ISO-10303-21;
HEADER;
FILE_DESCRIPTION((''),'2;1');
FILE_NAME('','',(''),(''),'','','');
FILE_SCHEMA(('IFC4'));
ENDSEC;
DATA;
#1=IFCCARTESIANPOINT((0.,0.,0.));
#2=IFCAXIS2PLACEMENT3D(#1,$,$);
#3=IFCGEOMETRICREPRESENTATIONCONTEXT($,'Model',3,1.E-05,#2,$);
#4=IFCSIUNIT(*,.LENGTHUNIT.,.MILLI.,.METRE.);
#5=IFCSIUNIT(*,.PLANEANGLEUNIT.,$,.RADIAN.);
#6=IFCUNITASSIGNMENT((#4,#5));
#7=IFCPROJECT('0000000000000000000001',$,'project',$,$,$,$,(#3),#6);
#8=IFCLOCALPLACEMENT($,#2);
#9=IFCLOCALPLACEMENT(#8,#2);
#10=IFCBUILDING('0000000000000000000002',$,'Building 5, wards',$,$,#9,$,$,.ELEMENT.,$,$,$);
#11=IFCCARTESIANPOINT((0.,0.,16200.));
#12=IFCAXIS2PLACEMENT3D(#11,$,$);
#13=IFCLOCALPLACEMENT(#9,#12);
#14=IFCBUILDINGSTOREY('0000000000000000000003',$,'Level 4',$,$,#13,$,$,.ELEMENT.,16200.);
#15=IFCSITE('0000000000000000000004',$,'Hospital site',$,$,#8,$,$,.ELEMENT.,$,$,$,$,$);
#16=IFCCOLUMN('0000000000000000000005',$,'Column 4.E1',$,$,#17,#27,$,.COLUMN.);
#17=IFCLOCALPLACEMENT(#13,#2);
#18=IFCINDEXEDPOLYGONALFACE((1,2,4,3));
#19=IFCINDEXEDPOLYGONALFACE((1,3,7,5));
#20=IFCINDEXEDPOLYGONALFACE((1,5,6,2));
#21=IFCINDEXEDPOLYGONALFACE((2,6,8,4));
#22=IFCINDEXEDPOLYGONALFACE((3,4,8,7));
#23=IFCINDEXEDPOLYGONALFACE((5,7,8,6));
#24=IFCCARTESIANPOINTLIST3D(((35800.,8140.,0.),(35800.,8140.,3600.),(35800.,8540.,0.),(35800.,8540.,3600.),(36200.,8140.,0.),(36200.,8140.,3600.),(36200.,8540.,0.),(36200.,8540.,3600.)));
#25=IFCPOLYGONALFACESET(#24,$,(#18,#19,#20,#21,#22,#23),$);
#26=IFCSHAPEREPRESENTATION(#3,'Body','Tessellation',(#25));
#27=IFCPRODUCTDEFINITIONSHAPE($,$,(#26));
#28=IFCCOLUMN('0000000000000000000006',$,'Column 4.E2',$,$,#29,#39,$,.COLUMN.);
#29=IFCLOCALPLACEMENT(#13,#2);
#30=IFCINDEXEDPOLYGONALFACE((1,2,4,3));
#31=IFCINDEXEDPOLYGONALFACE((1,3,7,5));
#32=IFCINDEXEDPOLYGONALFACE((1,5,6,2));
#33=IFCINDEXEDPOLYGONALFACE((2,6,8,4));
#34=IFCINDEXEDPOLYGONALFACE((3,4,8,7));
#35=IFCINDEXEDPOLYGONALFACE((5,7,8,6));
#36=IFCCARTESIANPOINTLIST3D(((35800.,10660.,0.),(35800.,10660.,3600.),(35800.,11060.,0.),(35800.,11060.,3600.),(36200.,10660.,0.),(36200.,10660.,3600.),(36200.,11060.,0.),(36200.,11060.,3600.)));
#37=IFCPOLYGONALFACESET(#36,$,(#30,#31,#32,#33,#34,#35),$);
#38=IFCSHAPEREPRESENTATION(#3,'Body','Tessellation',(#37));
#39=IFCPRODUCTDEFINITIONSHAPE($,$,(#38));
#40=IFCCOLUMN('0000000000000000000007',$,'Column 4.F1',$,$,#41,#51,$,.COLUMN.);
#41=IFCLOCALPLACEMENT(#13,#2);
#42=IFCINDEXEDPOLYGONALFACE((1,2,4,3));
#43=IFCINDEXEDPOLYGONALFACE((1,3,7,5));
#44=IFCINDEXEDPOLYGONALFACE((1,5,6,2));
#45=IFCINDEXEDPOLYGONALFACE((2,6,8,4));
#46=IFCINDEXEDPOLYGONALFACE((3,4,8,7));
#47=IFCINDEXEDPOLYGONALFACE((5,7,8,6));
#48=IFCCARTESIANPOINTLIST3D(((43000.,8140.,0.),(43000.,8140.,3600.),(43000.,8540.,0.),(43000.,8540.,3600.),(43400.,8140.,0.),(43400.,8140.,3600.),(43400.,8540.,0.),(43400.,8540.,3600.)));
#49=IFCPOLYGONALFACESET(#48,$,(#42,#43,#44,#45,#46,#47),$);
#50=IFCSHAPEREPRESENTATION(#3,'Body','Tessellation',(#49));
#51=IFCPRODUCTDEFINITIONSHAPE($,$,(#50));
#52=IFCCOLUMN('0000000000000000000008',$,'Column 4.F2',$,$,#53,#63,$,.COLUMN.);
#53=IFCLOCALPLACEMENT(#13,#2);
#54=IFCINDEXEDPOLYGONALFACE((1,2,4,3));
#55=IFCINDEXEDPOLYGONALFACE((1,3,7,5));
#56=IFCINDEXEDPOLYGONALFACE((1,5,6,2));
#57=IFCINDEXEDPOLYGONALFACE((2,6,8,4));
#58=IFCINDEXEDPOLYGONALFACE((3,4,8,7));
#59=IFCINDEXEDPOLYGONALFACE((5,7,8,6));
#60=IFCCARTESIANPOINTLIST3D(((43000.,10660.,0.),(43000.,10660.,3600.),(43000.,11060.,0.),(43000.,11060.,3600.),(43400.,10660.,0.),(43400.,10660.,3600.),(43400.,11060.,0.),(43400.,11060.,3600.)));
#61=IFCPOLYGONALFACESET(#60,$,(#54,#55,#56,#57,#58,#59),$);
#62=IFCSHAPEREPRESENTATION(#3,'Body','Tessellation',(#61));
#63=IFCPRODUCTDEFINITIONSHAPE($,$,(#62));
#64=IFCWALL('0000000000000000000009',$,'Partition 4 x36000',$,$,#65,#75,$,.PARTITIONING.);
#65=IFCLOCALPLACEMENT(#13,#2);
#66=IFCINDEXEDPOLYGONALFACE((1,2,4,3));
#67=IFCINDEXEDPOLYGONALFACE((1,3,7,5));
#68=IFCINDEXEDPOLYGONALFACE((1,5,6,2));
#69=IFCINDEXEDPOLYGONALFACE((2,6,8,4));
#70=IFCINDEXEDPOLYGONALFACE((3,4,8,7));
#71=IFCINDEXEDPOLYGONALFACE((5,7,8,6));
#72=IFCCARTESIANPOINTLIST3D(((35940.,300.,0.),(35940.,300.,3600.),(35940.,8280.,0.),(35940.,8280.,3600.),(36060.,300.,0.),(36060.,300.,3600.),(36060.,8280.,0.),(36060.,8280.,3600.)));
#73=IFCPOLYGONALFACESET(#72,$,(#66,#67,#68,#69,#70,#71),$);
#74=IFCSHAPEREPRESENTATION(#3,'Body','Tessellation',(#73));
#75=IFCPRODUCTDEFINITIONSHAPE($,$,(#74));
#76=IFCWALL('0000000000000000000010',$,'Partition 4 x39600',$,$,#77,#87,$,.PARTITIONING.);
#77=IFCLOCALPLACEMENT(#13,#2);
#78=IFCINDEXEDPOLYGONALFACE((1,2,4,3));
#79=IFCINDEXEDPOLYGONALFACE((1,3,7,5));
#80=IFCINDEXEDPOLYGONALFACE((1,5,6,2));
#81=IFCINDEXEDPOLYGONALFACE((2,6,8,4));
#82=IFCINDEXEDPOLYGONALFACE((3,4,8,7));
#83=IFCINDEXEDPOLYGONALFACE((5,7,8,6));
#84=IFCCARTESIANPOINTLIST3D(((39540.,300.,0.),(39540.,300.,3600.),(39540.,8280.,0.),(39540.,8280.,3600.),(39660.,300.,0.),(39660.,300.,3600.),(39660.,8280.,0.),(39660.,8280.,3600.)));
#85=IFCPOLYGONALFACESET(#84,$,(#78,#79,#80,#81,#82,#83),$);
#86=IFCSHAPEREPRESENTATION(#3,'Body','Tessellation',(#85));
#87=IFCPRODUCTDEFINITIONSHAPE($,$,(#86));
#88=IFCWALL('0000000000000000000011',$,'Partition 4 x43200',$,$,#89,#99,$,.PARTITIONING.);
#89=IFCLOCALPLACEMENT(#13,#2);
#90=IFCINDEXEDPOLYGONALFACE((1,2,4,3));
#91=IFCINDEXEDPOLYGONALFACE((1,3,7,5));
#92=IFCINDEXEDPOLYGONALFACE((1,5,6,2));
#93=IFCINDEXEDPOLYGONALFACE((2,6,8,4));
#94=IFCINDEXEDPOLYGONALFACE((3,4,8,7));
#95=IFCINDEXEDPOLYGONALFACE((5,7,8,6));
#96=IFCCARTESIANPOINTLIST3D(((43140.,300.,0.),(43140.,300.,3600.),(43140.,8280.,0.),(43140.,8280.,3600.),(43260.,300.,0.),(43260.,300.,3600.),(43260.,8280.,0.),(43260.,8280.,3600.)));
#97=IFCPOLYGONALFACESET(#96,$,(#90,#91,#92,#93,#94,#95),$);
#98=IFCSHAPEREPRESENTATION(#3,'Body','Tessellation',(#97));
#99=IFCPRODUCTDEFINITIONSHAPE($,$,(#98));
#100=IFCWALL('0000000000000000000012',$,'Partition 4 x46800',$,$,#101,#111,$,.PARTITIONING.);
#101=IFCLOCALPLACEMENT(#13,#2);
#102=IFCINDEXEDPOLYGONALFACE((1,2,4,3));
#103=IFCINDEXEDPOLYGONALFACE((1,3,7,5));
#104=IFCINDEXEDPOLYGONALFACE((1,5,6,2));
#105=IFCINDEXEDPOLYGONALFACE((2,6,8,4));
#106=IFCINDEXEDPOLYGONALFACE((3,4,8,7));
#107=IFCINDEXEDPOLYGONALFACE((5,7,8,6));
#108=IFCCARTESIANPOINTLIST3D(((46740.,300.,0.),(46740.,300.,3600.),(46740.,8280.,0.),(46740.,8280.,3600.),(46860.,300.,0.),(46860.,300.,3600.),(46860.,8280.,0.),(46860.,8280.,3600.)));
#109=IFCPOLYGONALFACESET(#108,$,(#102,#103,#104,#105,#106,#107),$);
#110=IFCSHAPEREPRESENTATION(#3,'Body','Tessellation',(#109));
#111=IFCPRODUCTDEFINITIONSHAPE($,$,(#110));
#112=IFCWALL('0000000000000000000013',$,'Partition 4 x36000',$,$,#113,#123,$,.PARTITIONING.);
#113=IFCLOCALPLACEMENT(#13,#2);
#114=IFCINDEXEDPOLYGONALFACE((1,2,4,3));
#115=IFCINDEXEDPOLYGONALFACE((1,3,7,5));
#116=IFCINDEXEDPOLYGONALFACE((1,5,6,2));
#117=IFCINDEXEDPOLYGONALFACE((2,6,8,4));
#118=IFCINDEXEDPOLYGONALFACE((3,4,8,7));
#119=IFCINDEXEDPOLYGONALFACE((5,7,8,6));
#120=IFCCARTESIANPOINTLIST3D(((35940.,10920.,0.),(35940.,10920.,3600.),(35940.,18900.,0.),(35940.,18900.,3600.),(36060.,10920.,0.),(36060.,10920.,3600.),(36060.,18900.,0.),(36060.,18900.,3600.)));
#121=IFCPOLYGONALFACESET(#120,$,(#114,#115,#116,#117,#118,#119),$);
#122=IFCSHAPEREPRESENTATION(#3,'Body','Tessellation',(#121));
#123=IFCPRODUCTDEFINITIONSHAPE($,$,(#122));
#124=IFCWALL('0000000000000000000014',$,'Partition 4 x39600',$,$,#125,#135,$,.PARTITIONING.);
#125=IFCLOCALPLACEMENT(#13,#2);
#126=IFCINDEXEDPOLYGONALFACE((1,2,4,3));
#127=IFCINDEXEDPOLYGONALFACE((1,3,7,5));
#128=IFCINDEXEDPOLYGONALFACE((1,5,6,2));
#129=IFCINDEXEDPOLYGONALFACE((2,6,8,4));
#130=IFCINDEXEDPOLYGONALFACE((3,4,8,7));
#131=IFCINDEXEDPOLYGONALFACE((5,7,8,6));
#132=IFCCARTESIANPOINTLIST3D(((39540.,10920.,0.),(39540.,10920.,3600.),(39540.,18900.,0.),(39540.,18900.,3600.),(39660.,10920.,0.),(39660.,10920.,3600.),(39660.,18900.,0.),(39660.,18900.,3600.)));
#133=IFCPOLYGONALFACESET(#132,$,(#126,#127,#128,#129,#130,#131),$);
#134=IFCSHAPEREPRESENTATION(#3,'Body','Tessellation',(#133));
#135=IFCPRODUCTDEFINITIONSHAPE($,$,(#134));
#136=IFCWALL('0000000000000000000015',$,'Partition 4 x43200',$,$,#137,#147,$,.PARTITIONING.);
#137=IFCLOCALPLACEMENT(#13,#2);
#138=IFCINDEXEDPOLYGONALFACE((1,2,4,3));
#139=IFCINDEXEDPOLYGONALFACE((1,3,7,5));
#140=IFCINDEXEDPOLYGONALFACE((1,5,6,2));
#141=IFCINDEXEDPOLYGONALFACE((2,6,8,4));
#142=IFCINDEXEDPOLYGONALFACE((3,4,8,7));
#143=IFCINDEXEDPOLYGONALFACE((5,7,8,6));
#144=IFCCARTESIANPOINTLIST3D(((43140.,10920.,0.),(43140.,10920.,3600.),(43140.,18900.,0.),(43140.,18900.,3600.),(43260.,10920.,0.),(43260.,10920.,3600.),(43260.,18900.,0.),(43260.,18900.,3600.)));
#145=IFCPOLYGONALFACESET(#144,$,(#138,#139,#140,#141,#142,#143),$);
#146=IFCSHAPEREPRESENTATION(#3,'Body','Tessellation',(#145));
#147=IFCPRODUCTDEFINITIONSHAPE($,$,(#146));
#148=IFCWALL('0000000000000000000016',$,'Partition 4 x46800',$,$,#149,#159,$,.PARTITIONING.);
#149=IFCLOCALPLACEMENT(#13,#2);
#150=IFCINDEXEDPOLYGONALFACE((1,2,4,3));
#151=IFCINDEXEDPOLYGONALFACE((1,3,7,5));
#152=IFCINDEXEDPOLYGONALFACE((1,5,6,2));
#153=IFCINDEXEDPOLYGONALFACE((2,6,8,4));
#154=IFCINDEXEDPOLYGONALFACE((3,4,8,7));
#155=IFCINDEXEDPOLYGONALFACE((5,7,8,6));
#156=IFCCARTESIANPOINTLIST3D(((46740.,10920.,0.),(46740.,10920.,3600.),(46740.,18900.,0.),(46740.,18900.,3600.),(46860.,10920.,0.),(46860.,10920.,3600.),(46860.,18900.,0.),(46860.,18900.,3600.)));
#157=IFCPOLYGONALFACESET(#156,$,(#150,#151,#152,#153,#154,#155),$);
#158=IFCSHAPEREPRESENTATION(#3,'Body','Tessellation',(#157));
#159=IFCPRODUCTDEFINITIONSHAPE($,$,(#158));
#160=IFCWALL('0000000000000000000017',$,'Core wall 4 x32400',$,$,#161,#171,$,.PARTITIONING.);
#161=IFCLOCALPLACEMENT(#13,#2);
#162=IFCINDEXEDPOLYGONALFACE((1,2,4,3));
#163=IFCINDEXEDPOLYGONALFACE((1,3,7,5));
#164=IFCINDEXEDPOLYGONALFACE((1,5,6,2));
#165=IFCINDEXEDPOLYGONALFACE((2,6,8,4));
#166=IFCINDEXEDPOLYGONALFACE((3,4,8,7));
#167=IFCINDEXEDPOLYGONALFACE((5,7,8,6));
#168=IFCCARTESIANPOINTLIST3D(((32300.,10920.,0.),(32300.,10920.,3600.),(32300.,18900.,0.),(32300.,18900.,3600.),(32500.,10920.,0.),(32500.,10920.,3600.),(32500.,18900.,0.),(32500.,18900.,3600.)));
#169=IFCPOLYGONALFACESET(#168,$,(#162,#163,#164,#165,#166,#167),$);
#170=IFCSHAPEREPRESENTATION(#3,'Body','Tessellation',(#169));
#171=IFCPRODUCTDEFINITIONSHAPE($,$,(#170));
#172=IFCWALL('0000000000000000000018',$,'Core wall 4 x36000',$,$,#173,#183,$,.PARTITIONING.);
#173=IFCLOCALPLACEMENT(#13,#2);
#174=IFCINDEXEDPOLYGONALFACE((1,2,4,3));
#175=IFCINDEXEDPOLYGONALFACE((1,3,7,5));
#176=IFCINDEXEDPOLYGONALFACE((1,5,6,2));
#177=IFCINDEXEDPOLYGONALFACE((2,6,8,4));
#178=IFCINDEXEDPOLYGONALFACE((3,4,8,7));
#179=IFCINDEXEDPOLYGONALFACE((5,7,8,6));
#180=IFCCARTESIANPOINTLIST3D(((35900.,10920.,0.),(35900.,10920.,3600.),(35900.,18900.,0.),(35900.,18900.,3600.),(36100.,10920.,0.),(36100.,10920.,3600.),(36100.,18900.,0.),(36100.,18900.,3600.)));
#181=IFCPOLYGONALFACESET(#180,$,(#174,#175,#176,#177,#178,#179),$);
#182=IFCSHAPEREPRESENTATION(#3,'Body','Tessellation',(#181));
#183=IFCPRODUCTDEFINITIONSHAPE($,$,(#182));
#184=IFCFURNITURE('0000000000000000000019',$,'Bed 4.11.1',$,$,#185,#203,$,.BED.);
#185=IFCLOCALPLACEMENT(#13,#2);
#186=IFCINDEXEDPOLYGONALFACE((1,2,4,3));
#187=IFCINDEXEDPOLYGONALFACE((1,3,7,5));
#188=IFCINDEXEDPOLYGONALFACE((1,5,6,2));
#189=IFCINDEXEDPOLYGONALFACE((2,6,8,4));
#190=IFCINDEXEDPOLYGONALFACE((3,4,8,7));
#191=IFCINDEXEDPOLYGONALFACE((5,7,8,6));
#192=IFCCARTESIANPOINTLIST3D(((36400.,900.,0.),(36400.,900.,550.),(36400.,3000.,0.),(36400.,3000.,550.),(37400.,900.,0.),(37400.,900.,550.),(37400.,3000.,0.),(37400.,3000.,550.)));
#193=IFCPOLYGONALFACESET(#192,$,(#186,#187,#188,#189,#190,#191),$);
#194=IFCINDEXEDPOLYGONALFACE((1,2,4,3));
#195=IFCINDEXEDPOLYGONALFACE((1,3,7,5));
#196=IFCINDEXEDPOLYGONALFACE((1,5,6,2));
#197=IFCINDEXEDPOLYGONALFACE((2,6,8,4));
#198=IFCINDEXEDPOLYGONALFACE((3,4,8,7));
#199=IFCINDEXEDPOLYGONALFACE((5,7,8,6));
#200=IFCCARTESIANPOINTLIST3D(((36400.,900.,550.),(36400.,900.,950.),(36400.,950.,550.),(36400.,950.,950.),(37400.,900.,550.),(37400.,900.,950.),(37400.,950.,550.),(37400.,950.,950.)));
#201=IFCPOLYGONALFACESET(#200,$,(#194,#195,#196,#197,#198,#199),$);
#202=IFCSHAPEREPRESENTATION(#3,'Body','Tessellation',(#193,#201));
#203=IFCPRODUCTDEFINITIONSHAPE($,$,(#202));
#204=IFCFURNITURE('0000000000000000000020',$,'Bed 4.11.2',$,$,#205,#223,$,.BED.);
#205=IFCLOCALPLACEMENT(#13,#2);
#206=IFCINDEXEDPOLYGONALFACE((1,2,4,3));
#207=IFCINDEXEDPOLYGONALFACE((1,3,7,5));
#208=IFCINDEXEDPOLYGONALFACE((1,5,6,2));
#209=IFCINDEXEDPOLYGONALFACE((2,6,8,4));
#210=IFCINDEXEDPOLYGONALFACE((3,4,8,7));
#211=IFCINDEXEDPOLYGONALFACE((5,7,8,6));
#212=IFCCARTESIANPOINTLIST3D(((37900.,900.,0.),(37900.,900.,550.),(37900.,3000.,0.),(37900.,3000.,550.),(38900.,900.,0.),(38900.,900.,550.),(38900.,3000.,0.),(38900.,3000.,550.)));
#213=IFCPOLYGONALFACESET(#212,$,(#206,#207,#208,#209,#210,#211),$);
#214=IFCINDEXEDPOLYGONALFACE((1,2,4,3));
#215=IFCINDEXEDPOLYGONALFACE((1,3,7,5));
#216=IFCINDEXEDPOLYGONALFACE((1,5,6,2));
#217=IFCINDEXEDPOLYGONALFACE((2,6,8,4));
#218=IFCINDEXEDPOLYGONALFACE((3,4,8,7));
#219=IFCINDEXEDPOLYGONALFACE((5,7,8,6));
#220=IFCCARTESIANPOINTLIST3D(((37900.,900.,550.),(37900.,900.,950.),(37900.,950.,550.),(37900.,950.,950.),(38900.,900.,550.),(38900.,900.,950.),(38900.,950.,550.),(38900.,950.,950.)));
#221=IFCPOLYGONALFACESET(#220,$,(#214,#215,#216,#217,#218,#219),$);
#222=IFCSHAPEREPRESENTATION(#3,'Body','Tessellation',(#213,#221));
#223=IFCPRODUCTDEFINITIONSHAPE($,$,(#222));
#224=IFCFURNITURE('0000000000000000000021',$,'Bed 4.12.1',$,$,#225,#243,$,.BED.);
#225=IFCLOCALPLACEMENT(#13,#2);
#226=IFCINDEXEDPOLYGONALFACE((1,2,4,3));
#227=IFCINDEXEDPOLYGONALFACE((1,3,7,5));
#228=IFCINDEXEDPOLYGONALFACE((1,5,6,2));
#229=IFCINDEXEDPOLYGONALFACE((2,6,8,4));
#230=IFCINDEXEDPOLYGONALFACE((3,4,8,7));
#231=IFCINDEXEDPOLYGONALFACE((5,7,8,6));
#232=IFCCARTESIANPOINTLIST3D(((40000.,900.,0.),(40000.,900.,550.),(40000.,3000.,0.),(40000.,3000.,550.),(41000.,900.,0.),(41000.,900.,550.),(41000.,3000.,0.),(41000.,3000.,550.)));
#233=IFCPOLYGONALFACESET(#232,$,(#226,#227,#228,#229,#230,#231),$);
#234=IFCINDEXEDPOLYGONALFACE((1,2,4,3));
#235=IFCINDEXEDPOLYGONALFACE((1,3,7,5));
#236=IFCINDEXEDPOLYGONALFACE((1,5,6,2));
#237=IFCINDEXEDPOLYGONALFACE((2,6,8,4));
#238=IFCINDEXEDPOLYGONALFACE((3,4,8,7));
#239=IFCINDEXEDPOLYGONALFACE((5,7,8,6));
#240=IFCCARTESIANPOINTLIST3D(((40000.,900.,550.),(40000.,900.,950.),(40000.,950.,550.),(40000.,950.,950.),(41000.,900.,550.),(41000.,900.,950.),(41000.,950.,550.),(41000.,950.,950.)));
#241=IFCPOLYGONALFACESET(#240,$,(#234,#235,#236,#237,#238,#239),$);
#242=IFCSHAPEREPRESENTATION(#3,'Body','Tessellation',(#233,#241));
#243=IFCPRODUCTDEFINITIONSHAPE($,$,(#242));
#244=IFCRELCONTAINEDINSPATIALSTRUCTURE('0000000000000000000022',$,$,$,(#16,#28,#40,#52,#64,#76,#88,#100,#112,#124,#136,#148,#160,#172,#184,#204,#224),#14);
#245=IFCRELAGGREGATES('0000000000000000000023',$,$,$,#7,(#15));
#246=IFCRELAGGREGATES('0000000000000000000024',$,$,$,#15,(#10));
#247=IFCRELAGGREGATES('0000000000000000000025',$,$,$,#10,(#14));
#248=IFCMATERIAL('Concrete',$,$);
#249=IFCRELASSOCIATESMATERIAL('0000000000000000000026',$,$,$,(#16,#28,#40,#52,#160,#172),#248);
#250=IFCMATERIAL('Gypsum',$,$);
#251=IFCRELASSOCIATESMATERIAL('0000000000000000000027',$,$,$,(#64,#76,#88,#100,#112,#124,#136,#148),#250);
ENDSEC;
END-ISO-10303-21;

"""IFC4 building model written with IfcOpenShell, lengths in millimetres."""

from ifc_helpers import new_model, si_unit, frame, frame_2d, origin, origin_2d, place, context, project, spatial, rectangle, extrude, material, element, save


model = new_model("IFC4")

# Units and contexts
model_context = context("Model", 3, precision=1e-05, world=origin())
ifc_project = project(units=[si_unit("LENGTHUNIT", "METRE", prefix="MILLI"), si_unit("PLANEANGLEUNIT", "RADIAN")], contexts=[model_context])

# Site, building, storey
site_placement = place(None, origin())
site = spatial("IfcSite", under=ifc_project, at=site_placement, Name="Hospital site", CompositionType="ELEMENT")
building_placement = place(site_placement, origin())
building = spatial("IfcBuilding", under=site, at=building_placement, Name="Building 5, wards", CompositionType="ELEMENT")
storey_placement = place(building_placement, frame((0.0, 0.0, 16200.0)))
storey = spatial("IfcBuildingStorey", under=building, at=storey_placement, Name="Level 4", CompositionType="ELEMENT", Elevation=16200.0)

# Columns
ifc_material_1 = material(Name="Concrete")
for number, where, name in (
    (1, (36000.0, 8340.0, 0.0), "Column 4.E1"),
    (2, (36000.0, 10860.0, 0.0), "Column 4.E2"),
    (3, (43200.0, 8340.0, 0.0), "Column 4.F1"),
    (4, (43200.0, 10860.0, 0.0), "Column 4.F2"),
):
    element("IfcColumn", number, at=place(storey_placement, frame(where)), inside=storey, material=ifc_material_1, Name=name, PredefinedType="COLUMN", context=model_context, shape_type="SweptSolid", body=[
        extrude(rectangle(XDim=400.0, YDim=400.0, at=origin_2d()), origin(), (0.0, 0.0, 1.0), 3600.0),
    ])

# Walls
ifc_material_2 = material(Name="Gypsum")
for number, where, x_axis, name in (
    (5, (36060.0, 300.0, 0.0), (0.0, 1.0, 0.0), "Partition 4 x36000"),
    (6, (39660.0, 300.0, 0.0), (0.0, 1.0, 0.0), "Partition 4 x39600"),
    (7, (43260.0, 300.0, 0.0), (0.0, 1.0, 0.0), "Partition 4 x43200"),
    (8, (46860.0, 300.0, 0.0), (0.0, 1.0, 0.0), "Partition 4 x46800"),
    (9, (36060.0, 10920.0, 0.0), (0.0, 1.0, 0.0), "Partition 4 x36000"),
    (10, (39660.0, 10920.0, 0.0), (0.0, 1.0, 0.0), "Partition 4 x39600"),
    (11, (43260.0, 10920.0, 0.0), (0.0, 1.0, 0.0), "Partition 4 x43200"),
    (12, (46860.0, 10920.0, 0.0), (0.0, 1.0, 0.0), "Partition 4 x46800"),
):
    element("IfcWall", number, at=place(storey_placement, frame(where, x_axis=x_axis)), inside=storey, material=ifc_material_2, Name=name, PredefinedType="PARTITIONING", context=model_context, shape_type="SweptSolid", body=[
        extrude(rectangle(XDim=7980.0, YDim=120.0, at=frame_2d((3990.0, 60.0))), origin(), (0.0, 0.0, 1.0), 3600.0),
    ])
for number, where, x_axis, name in (
    (13, (32500.0, 10920.0, 0.0), (0.0, 1.0, 0.0), "Core wall 4 x32400"),
    (14, (36100.0, 10920.0, 0.0), (0.0, 1.0, 0.0), "Core wall 4 x36000"),
):
    element("IfcWall", number, at=place(storey_placement, frame(where, x_axis=x_axis)), inside=storey, material=ifc_material_1, Name=name, PredefinedType="PARTITIONING", context=model_context, shape_type="SweptSolid", body=[
        extrude(rectangle(XDim=7980.0, YDim=200.0, at=frame_2d((3990.0, 100.0))), origin(), (0.0, 0.0, 1.0), 3600.0),
    ])

# Furniture
for number, where, name in (
    (15, (36400.0, 900.0, 0.0), "Bed 4.11.1"),
    (16, (37900.0, 900.0, 0.0), "Bed 4.11.2"),
    (17, (40000.0, 900.0, 0.0), "Bed 4.12.1"),
):
    element("IfcFurniture", number, at=place(storey_placement, frame(where)), inside=storey, Name=name, PredefinedType="BED", context=model_context, shape_type="SweptSolid", body=[
        extrude(rectangle(XDim=1000.0, YDim=2100.0, at=frame_2d((500.0, 1050.0))), origin(), (0.0, 0.0, 1.0), 550.0),
        extrude(rectangle(XDim=1000.0, YDim=50.0, at=frame_2d((500.0, 25.0))), frame((0.0, 0.0, 550.0)), (0.0, 0.0, 1.0), 400.0),
    ])

save(model, "model.ifc")
